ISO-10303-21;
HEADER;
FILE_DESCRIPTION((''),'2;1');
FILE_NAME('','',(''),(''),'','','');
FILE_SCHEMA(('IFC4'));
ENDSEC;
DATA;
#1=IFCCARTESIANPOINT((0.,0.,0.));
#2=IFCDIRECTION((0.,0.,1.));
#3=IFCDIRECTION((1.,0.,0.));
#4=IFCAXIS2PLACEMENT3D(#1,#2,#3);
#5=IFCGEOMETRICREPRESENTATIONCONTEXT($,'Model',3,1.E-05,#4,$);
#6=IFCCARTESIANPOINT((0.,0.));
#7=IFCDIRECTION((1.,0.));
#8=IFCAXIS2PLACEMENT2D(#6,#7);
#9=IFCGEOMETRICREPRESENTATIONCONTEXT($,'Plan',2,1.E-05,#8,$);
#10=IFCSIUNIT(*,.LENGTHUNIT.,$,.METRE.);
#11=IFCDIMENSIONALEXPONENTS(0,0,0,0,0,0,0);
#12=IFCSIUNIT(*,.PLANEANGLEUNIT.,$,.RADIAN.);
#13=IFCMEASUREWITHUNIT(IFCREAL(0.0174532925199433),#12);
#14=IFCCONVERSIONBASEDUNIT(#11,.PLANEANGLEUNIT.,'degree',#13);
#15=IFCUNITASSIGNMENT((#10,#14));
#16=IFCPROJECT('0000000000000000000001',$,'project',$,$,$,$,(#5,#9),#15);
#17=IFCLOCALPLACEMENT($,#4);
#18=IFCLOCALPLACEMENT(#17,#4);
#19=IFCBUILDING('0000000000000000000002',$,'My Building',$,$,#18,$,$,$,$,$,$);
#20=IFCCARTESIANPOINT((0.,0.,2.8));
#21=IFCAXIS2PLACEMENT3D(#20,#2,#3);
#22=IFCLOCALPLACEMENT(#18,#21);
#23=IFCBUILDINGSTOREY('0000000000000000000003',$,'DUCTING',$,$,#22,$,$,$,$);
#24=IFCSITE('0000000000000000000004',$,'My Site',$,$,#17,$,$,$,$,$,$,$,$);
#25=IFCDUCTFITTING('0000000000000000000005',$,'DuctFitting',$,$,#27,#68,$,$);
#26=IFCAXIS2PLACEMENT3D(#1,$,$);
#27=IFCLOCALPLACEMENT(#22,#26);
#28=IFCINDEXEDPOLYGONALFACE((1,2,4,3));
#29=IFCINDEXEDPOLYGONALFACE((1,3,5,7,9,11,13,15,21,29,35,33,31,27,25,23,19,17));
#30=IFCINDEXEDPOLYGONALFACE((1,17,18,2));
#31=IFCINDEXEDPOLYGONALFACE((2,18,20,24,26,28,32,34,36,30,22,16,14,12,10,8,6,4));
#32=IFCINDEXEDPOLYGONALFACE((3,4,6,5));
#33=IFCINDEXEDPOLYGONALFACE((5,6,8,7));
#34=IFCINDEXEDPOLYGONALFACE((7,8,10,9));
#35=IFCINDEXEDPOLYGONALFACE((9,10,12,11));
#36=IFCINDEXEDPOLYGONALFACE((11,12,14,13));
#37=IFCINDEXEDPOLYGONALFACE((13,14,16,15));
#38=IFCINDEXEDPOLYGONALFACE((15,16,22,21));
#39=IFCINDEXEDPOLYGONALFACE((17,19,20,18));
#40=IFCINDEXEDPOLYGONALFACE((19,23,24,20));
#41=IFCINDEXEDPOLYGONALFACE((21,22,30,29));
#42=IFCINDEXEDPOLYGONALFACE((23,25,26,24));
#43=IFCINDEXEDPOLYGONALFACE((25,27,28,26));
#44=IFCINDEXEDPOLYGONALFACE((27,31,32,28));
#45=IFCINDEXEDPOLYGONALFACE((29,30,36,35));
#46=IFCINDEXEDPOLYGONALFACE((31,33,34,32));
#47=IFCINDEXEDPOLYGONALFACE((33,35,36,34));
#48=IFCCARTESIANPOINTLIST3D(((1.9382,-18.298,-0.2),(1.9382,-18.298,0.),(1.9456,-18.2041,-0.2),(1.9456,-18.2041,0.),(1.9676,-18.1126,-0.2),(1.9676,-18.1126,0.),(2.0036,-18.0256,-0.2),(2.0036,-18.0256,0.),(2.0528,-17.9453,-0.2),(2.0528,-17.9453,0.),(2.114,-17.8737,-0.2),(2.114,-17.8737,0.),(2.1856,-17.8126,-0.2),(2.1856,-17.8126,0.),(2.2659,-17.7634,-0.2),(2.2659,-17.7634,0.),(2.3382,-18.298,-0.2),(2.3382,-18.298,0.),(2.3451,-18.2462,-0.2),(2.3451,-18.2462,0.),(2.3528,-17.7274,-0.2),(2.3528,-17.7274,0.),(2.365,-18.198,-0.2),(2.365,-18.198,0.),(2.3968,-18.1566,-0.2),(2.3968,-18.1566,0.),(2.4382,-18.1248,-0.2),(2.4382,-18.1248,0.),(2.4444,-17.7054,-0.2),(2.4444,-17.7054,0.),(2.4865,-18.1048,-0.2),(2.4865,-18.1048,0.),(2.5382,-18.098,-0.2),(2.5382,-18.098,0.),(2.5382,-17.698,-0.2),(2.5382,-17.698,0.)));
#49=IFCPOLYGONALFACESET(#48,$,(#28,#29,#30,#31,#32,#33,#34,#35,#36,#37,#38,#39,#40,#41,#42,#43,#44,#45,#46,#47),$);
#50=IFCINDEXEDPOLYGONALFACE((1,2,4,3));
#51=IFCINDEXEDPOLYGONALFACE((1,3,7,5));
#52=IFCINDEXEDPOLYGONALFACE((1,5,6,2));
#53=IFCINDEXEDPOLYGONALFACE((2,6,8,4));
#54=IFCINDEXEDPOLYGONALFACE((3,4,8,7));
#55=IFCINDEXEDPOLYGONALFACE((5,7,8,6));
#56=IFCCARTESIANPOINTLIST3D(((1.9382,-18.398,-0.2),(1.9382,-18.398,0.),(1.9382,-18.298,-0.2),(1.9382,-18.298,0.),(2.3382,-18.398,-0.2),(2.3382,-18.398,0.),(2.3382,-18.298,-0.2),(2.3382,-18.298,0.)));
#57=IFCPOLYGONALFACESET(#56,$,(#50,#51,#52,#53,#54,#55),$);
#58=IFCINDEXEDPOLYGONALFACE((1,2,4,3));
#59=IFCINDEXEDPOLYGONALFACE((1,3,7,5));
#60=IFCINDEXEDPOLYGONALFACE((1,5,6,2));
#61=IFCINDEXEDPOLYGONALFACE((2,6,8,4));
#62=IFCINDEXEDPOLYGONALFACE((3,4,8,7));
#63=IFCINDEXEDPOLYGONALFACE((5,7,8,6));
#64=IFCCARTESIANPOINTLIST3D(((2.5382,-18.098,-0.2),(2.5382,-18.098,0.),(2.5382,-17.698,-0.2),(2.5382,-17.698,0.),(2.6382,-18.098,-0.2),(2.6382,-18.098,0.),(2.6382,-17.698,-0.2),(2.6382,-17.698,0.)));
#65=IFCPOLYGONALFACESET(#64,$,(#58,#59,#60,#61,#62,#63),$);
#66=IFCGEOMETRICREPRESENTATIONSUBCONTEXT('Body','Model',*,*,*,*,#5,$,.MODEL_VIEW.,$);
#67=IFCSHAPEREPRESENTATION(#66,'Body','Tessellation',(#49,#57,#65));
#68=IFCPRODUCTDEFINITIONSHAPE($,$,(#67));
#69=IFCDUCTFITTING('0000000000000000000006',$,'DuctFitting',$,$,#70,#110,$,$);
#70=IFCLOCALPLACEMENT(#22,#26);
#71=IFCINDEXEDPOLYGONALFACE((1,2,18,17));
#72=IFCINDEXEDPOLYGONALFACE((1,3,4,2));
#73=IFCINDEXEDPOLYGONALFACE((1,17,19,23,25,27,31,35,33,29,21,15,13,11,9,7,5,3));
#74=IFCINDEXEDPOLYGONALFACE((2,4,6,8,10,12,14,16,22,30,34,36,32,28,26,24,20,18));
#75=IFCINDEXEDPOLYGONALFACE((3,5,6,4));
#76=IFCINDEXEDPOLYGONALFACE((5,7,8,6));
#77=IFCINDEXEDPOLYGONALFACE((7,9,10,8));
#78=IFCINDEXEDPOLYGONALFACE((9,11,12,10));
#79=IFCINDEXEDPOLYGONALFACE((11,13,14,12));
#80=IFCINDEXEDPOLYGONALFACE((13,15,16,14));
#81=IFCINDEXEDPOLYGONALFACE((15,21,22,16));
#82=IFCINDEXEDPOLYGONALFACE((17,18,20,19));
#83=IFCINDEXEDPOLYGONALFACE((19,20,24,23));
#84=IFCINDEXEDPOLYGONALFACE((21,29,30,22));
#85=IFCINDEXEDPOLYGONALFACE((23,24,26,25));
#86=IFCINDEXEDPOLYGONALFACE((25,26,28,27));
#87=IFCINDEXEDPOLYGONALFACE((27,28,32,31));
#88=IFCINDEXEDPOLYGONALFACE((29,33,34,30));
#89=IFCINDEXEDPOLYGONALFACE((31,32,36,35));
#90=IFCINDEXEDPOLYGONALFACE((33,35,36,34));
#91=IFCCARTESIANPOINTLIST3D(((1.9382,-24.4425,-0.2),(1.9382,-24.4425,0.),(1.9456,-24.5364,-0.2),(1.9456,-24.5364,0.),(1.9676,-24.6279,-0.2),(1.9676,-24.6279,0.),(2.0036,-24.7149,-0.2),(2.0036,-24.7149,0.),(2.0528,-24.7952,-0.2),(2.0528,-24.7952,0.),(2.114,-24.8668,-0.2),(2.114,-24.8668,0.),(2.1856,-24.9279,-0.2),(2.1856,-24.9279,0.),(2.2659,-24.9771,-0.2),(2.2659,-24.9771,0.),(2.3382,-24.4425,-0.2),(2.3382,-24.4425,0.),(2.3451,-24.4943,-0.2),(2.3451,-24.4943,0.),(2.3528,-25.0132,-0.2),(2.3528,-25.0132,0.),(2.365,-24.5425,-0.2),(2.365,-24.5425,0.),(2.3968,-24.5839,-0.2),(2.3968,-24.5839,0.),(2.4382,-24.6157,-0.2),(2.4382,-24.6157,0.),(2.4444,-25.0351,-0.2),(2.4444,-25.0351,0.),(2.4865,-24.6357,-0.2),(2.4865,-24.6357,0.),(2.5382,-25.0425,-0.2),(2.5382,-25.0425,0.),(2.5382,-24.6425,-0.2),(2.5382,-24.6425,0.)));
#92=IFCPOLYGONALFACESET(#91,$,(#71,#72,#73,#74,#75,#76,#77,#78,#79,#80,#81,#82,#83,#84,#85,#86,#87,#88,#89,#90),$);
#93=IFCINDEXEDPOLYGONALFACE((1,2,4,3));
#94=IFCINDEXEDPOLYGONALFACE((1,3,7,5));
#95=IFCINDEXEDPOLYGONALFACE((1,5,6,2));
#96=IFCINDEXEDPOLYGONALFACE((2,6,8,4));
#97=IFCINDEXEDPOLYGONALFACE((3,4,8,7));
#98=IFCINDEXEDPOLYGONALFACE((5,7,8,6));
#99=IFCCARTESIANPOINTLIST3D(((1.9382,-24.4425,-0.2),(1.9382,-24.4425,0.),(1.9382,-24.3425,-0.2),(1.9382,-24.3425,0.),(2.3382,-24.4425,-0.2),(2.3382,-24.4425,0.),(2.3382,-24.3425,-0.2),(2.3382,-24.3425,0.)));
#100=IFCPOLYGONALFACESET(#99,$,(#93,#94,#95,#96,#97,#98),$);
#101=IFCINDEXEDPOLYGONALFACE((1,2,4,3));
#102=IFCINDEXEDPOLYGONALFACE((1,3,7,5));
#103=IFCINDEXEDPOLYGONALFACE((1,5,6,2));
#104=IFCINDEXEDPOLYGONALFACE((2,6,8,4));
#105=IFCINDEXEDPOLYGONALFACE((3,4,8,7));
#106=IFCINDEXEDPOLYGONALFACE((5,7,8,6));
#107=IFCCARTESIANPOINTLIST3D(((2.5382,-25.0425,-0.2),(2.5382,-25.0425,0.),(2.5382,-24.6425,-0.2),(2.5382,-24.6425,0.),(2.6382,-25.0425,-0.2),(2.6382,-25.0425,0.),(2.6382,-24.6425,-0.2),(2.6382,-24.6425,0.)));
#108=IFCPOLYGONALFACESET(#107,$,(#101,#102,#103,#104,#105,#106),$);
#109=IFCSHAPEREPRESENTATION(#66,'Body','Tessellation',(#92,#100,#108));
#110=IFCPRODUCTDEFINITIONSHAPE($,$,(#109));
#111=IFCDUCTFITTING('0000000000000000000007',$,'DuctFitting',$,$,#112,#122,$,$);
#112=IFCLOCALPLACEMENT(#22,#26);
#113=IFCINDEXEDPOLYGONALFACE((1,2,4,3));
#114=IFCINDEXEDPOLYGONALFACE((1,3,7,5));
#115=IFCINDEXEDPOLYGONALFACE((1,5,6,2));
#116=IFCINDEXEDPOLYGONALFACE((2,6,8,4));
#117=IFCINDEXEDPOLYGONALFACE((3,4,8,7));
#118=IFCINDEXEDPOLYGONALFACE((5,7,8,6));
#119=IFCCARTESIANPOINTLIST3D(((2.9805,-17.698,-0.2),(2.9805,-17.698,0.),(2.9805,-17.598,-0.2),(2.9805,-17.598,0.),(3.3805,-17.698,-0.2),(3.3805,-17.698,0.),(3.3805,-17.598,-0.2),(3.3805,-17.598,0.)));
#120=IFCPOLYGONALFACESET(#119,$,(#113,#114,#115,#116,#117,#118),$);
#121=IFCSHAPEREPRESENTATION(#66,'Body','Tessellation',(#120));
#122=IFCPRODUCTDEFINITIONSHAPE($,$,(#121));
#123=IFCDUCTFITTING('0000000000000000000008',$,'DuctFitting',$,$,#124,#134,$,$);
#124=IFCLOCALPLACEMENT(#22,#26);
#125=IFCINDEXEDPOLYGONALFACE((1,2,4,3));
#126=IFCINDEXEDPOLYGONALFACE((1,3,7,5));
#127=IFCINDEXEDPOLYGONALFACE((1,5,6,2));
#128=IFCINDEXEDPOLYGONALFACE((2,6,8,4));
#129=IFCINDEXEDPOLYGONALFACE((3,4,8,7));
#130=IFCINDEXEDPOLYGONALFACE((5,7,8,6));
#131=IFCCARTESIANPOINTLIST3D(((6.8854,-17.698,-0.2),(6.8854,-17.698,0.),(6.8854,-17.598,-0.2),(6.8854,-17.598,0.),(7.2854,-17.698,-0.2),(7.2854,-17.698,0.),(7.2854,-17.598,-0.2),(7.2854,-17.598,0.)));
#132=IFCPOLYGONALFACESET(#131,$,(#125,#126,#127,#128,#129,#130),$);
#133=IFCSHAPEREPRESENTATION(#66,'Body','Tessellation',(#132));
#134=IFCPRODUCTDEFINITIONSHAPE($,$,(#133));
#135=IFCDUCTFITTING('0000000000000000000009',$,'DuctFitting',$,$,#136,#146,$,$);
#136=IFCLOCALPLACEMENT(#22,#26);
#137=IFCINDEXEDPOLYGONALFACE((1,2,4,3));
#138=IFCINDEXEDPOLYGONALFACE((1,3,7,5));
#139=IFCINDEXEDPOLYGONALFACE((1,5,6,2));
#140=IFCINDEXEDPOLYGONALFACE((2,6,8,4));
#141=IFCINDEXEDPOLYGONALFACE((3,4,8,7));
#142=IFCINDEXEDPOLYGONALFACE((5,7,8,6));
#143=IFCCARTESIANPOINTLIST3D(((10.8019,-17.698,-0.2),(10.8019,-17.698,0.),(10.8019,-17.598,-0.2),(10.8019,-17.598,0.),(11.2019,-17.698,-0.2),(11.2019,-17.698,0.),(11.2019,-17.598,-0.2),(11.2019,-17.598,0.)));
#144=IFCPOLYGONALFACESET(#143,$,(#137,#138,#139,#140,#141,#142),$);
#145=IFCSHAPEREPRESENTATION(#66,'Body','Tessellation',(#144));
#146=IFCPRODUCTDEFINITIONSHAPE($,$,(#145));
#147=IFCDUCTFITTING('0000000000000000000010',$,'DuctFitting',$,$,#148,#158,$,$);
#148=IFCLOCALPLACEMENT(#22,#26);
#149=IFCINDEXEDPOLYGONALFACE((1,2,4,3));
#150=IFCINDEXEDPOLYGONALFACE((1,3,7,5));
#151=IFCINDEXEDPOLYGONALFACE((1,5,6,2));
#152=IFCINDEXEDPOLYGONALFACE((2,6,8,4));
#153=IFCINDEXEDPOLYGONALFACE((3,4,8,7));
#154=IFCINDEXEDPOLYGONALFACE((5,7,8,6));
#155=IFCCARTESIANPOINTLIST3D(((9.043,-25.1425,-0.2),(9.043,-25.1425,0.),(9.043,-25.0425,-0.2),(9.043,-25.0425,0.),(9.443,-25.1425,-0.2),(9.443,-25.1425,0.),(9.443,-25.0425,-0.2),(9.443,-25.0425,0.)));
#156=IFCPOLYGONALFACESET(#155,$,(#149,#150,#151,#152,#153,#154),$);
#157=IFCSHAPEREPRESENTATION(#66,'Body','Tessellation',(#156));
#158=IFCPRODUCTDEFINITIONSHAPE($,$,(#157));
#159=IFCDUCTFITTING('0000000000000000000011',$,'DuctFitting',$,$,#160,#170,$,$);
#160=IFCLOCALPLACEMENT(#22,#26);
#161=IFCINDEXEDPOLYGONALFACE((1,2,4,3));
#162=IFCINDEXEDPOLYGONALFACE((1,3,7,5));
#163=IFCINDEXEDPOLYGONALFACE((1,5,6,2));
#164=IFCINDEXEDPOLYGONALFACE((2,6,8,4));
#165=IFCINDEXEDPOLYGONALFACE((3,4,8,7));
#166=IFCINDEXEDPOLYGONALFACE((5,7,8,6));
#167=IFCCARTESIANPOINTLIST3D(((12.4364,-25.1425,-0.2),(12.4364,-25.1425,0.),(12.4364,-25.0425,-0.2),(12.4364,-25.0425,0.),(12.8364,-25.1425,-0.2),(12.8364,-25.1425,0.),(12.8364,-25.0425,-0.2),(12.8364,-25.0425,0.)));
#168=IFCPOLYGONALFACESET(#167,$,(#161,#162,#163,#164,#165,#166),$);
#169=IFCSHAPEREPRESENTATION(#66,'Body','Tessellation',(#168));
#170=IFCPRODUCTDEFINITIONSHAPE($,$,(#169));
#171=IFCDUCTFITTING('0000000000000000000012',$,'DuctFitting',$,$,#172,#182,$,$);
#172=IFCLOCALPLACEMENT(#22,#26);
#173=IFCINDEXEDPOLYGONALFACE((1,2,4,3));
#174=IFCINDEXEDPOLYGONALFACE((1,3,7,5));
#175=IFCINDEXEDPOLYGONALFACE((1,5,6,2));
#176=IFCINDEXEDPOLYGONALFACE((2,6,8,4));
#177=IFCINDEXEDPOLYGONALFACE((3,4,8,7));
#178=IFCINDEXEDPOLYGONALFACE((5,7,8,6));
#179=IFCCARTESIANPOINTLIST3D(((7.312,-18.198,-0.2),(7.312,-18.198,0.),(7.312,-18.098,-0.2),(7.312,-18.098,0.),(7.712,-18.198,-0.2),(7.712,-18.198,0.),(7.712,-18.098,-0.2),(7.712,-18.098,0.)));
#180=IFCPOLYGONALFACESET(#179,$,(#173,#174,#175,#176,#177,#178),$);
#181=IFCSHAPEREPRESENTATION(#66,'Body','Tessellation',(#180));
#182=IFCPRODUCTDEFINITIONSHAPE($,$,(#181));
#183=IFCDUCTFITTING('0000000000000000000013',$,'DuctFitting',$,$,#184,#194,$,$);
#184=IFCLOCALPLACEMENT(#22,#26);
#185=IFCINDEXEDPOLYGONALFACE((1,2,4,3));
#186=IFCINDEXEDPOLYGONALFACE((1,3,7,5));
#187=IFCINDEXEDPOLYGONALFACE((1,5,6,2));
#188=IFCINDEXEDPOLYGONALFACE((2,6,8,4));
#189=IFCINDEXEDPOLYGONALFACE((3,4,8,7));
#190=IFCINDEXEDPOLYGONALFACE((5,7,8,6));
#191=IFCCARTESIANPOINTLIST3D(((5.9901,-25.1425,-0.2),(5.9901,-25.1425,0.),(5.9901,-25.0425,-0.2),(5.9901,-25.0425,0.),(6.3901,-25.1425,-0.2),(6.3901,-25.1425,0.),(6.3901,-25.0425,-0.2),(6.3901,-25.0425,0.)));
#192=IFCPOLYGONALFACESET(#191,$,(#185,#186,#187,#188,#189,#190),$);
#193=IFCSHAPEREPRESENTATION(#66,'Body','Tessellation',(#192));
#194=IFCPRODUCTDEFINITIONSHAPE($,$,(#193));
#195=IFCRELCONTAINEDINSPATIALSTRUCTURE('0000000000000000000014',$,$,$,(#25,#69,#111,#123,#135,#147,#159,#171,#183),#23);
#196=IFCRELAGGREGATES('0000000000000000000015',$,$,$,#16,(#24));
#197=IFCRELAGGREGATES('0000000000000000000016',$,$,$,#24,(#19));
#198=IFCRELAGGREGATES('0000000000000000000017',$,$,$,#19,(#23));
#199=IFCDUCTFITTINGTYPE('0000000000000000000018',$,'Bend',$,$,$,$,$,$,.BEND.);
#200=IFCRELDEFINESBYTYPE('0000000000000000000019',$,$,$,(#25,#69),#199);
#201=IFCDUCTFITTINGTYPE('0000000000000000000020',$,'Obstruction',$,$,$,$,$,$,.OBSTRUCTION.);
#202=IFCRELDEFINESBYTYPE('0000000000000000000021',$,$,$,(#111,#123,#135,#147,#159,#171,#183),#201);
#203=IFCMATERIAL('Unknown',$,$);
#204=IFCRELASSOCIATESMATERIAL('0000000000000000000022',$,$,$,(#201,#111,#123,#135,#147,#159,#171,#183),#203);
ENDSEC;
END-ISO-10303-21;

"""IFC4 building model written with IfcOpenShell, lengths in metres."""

from ifc_helpers import new_model, entity, si_unit, converted_unit, frame, origin_with_axes, origin_2d_with_axis, place, context, subcontext, project, spatial, line, arc, indexed_curve, rectangle, outline, extrude, source, transform, mapped, material, material_profile, profile_set, profile_usage, type_object, type_shapes, element, save


model = new_model("IFC4")

# Units and contexts
model_context = context("Model", 3, precision=1e-05, world=origin_with_axes())
plan_context = context("Plan", 2, precision=1e-05, world=origin_2d_with_axis())
body_context = subcontext(model_context, "Body", "Model", "MODEL_VIEW")
ifc_project = project(units=[si_unit("LENGTHUNIT", "METRE"), converted_unit("PLANEANGLEUNIT", "degree", entity("IfcReal", 0.0174532925199433), si_unit("PLANEANGLEUNIT", "RADIAN"), dimensions=[0, 0, 0, 0, 0, 0, 0])], contexts=[model_context, plan_context])

# Site, building, storey
site_placement = place(None, origin_with_axes())
site = spatial("IfcSite", under=ifc_project, at=site_placement, Name="My Site")
building_placement = place(site_placement, origin_with_axes())
building = spatial("IfcBuilding", under=site, at=building_placement, Name="My Building")
storey_placement = place(building_placement, frame((0.0, 0.0, 2.8), z_axis=(0.0, 0.0, 1.0), x_axis=(1.0, 0.0, 0.0)))
storey = spatial("IfcBuildingStorey", under=building, at=storey_placement, Name="DUCTING")

# Shared definitions
ifc_material = material(Name="Unknown")

# Duct fittings
duct_fitting_type_1 = type_object("IfcDuctFittingType", Name="Bend", PredefinedType="BEND")
shared_shape = source(origin_with_axes(), body_context, "Body", "SweptSolid", [
    extrude(outline(indexed_curve([(0.2, 0.0), (0.2586, -0.1414), (0.4, -0.2), (0.4, -0.6), (-0.0243, -0.4243), (-0.2, 0.0)], segments=[arc(1, 2, 3), line(3, 4), arc(4, 5, 6), line(6, 1)])), frame((0.0, -0.1, -0.1), z_axis=(0.0, -1.0, 0.0), x_axis=(1.0, 0.0, 0.0)), (0.0, 0.0, -1.0), 0.2),
    extrude(rectangle(XDim=0.4, YDim=0.2), origin_with_axes(), (0.0, 0.0, -1.0), 0.1),
    extrude(rectangle(XDim=0.4, YDim=0.2), frame((0.4, 0.0, -0.5), z_axis=(1.0, 0.0, 0.0), x_axis=(0.0, 0.0, 1.0)), (0.0, 0.0, 1.0), 0.1),
])
type_shapes(duct_fitting_type_1, [shared_shape])
for number, where, z_axis, x_axis, name in (
    (1, (2.1382, -18.398, -0.1), (0.0, -1.0, 0.0), (1.0, 0.0, 0.0), "DuctFitting"),
    (2, (2.1382, -24.3425, -0.1), (0.0, 1.0, 0.0), (1.0, 0.0, 0.0), "DuctFitting"),
):
    element("IfcDuctFitting", number, at=place(storey_placement, frame(where, z_axis=z_axis, x_axis=x_axis)), inside=storey, type_object=duct_fitting_type_1, Name=name, context=body_context, shape_type="MappedRepresentation", body=[
        mapped(shared_shape, transform((0.0, 0.0, 0.0), x_axis=(1.0, 0.0, 0.0), y_axis=(0.0, 1.0, 0.0), z_axis=(0.0, 0.0, 1.0), scale=1.0)),
    ])
ifc_material_profile_1 = material_profile(ifc_material, rectangle(XDim=0.4, YDim=0.2))
ifc_profile_set_1 = profile_set([ifc_material_profile_1])
ifc_profile_usage_1 = profile_usage(ifc_profile_set_1, cardinal=5)
duct_fitting_type_2 = type_object("IfcDuctFittingType", Name="Obstruction", PredefinedType="OBSTRUCTION", material=ifc_profile_set_1)
duct_fitting_1_placement = place(storey_placement, frame((3.1805, -17.698, -0.1), z_axis=(0.0, 1.0, 0.0), x_axis=(-1.0, 0.0, 0.0)))
element("IfcDuctFitting", 3, at=duct_fitting_1_placement, inside=storey, type_object=duct_fitting_type_2, material=ifc_profile_usage_1, Name="DuctFitting", context=body_context, shape_type="SweptSolid", body=[
    extrude(rectangle(XDim=0.4, YDim=0.2), origin_with_axes(), (0.0, 0.0, 1.0), 0.1),
])
ifc_profile_usage_2 = profile_usage(ifc_profile_set_1, cardinal=5)
duct_fitting_2_placement = place(storey_placement, frame((7.0854, -17.698, -0.1), z_axis=(0.0, 1.0, 0.0), x_axis=(-1.0, 0.0, 0.0)))
element("IfcDuctFitting", 4, at=duct_fitting_2_placement, inside=storey, type_object=duct_fitting_type_2, material=ifc_profile_usage_2, Name="DuctFitting", context=body_context, shape_type="SweptSolid", body=[
    extrude(rectangle(XDim=0.4, YDim=0.2), origin_with_axes(), (0.0, 0.0, 1.0), 0.1),
])
ifc_profile_usage_3 = profile_usage(ifc_profile_set_1, cardinal=5)
duct_fitting_3_placement = place(storey_placement, frame((11.0019, -17.698, -0.1), z_axis=(0.0, 1.0, 0.0), x_axis=(-1.0, 0.0, 0.0)))
element("IfcDuctFitting", 5, at=duct_fitting_3_placement, inside=storey, type_object=duct_fitting_type_2, material=ifc_profile_usage_3, Name="DuctFitting", context=body_context, shape_type="SweptSolid", body=[
    extrude(rectangle(XDim=0.4, YDim=0.2), origin_with_axes(), (0.0, 0.0, 1.0), 0.1),
])
ifc_profile_usage_4 = profile_usage(ifc_profile_set_1, cardinal=5)
duct_fitting_4_placement = place(storey_placement, frame((9.243, -25.0425, -0.1), z_axis=(0.0, -1.0, 0.0), x_axis=(1.0, 0.0, 0.0)))
element("IfcDuctFitting", 6, at=duct_fitting_4_placement, inside=storey, type_object=duct_fitting_type_2, material=ifc_profile_usage_4, Name="DuctFitting", context=body_context, shape_type="SweptSolid", body=[
    extrude(rectangle(XDim=0.4, YDim=0.2), origin_with_axes(), (0.0, 0.0, 1.0), 0.1),
])
ifc_profile_usage_5 = profile_usage(ifc_profile_set_1, cardinal=5)
duct_fitting_5_placement = place(storey_placement, frame((12.6364, -25.0425, -0.1), z_axis=(0.0, -1.0, 0.0), x_axis=(1.0, 0.0, 0.0)))
element("IfcDuctFitting", 7, at=duct_fitting_5_placement, inside=storey, type_object=duct_fitting_type_2, material=ifc_profile_usage_5, Name="DuctFitting", context=body_context, shape_type="SweptSolid", body=[
    extrude(rectangle(XDim=0.4, YDim=0.2), origin_with_axes(), (0.0, 0.0, 1.0), 0.1),
])
ifc_profile_usage_6 = profile_usage(ifc_profile_set_1, cardinal=5)
duct_fitting_6_placement = place(storey_placement, frame((7.512, -18.098, -0.1), z_axis=(0.0, -1.0, 0.0), x_axis=(1.0, 0.0, 0.0)))
element("IfcDuctFitting", 8, at=duct_fitting_6_placement, inside=storey, type_object=duct_fitting_type_2, material=ifc_profile_usage_6, Name="DuctFitting", context=body_context, shape_type="SweptSolid", body=[
    extrude(rectangle(XDim=0.4, YDim=0.2), origin_with_axes(), (0.0, 0.0, 1.0), 0.1),
])
ifc_profile_usage_7 = profile_usage(ifc_profile_set_1, cardinal=5)
duct_fitting_7_placement = place(storey_placement, frame((6.1901, -25.1425, -0.1), z_axis=(0.0, 1.0, 0.0), x_axis=(-1.0, 0.0, 0.0)))
element("IfcDuctFitting", 9, at=duct_fitting_7_placement, inside=storey, type_object=duct_fitting_type_2, material=ifc_profile_usage_7, Name="DuctFitting", context=body_context, shape_type="SweptSolid", body=[
    extrude(rectangle(XDim=0.4, YDim=0.2), origin_with_axes(), (0.0, 0.0, 1.0), 0.1),
])

save(model, "model.ifc")
